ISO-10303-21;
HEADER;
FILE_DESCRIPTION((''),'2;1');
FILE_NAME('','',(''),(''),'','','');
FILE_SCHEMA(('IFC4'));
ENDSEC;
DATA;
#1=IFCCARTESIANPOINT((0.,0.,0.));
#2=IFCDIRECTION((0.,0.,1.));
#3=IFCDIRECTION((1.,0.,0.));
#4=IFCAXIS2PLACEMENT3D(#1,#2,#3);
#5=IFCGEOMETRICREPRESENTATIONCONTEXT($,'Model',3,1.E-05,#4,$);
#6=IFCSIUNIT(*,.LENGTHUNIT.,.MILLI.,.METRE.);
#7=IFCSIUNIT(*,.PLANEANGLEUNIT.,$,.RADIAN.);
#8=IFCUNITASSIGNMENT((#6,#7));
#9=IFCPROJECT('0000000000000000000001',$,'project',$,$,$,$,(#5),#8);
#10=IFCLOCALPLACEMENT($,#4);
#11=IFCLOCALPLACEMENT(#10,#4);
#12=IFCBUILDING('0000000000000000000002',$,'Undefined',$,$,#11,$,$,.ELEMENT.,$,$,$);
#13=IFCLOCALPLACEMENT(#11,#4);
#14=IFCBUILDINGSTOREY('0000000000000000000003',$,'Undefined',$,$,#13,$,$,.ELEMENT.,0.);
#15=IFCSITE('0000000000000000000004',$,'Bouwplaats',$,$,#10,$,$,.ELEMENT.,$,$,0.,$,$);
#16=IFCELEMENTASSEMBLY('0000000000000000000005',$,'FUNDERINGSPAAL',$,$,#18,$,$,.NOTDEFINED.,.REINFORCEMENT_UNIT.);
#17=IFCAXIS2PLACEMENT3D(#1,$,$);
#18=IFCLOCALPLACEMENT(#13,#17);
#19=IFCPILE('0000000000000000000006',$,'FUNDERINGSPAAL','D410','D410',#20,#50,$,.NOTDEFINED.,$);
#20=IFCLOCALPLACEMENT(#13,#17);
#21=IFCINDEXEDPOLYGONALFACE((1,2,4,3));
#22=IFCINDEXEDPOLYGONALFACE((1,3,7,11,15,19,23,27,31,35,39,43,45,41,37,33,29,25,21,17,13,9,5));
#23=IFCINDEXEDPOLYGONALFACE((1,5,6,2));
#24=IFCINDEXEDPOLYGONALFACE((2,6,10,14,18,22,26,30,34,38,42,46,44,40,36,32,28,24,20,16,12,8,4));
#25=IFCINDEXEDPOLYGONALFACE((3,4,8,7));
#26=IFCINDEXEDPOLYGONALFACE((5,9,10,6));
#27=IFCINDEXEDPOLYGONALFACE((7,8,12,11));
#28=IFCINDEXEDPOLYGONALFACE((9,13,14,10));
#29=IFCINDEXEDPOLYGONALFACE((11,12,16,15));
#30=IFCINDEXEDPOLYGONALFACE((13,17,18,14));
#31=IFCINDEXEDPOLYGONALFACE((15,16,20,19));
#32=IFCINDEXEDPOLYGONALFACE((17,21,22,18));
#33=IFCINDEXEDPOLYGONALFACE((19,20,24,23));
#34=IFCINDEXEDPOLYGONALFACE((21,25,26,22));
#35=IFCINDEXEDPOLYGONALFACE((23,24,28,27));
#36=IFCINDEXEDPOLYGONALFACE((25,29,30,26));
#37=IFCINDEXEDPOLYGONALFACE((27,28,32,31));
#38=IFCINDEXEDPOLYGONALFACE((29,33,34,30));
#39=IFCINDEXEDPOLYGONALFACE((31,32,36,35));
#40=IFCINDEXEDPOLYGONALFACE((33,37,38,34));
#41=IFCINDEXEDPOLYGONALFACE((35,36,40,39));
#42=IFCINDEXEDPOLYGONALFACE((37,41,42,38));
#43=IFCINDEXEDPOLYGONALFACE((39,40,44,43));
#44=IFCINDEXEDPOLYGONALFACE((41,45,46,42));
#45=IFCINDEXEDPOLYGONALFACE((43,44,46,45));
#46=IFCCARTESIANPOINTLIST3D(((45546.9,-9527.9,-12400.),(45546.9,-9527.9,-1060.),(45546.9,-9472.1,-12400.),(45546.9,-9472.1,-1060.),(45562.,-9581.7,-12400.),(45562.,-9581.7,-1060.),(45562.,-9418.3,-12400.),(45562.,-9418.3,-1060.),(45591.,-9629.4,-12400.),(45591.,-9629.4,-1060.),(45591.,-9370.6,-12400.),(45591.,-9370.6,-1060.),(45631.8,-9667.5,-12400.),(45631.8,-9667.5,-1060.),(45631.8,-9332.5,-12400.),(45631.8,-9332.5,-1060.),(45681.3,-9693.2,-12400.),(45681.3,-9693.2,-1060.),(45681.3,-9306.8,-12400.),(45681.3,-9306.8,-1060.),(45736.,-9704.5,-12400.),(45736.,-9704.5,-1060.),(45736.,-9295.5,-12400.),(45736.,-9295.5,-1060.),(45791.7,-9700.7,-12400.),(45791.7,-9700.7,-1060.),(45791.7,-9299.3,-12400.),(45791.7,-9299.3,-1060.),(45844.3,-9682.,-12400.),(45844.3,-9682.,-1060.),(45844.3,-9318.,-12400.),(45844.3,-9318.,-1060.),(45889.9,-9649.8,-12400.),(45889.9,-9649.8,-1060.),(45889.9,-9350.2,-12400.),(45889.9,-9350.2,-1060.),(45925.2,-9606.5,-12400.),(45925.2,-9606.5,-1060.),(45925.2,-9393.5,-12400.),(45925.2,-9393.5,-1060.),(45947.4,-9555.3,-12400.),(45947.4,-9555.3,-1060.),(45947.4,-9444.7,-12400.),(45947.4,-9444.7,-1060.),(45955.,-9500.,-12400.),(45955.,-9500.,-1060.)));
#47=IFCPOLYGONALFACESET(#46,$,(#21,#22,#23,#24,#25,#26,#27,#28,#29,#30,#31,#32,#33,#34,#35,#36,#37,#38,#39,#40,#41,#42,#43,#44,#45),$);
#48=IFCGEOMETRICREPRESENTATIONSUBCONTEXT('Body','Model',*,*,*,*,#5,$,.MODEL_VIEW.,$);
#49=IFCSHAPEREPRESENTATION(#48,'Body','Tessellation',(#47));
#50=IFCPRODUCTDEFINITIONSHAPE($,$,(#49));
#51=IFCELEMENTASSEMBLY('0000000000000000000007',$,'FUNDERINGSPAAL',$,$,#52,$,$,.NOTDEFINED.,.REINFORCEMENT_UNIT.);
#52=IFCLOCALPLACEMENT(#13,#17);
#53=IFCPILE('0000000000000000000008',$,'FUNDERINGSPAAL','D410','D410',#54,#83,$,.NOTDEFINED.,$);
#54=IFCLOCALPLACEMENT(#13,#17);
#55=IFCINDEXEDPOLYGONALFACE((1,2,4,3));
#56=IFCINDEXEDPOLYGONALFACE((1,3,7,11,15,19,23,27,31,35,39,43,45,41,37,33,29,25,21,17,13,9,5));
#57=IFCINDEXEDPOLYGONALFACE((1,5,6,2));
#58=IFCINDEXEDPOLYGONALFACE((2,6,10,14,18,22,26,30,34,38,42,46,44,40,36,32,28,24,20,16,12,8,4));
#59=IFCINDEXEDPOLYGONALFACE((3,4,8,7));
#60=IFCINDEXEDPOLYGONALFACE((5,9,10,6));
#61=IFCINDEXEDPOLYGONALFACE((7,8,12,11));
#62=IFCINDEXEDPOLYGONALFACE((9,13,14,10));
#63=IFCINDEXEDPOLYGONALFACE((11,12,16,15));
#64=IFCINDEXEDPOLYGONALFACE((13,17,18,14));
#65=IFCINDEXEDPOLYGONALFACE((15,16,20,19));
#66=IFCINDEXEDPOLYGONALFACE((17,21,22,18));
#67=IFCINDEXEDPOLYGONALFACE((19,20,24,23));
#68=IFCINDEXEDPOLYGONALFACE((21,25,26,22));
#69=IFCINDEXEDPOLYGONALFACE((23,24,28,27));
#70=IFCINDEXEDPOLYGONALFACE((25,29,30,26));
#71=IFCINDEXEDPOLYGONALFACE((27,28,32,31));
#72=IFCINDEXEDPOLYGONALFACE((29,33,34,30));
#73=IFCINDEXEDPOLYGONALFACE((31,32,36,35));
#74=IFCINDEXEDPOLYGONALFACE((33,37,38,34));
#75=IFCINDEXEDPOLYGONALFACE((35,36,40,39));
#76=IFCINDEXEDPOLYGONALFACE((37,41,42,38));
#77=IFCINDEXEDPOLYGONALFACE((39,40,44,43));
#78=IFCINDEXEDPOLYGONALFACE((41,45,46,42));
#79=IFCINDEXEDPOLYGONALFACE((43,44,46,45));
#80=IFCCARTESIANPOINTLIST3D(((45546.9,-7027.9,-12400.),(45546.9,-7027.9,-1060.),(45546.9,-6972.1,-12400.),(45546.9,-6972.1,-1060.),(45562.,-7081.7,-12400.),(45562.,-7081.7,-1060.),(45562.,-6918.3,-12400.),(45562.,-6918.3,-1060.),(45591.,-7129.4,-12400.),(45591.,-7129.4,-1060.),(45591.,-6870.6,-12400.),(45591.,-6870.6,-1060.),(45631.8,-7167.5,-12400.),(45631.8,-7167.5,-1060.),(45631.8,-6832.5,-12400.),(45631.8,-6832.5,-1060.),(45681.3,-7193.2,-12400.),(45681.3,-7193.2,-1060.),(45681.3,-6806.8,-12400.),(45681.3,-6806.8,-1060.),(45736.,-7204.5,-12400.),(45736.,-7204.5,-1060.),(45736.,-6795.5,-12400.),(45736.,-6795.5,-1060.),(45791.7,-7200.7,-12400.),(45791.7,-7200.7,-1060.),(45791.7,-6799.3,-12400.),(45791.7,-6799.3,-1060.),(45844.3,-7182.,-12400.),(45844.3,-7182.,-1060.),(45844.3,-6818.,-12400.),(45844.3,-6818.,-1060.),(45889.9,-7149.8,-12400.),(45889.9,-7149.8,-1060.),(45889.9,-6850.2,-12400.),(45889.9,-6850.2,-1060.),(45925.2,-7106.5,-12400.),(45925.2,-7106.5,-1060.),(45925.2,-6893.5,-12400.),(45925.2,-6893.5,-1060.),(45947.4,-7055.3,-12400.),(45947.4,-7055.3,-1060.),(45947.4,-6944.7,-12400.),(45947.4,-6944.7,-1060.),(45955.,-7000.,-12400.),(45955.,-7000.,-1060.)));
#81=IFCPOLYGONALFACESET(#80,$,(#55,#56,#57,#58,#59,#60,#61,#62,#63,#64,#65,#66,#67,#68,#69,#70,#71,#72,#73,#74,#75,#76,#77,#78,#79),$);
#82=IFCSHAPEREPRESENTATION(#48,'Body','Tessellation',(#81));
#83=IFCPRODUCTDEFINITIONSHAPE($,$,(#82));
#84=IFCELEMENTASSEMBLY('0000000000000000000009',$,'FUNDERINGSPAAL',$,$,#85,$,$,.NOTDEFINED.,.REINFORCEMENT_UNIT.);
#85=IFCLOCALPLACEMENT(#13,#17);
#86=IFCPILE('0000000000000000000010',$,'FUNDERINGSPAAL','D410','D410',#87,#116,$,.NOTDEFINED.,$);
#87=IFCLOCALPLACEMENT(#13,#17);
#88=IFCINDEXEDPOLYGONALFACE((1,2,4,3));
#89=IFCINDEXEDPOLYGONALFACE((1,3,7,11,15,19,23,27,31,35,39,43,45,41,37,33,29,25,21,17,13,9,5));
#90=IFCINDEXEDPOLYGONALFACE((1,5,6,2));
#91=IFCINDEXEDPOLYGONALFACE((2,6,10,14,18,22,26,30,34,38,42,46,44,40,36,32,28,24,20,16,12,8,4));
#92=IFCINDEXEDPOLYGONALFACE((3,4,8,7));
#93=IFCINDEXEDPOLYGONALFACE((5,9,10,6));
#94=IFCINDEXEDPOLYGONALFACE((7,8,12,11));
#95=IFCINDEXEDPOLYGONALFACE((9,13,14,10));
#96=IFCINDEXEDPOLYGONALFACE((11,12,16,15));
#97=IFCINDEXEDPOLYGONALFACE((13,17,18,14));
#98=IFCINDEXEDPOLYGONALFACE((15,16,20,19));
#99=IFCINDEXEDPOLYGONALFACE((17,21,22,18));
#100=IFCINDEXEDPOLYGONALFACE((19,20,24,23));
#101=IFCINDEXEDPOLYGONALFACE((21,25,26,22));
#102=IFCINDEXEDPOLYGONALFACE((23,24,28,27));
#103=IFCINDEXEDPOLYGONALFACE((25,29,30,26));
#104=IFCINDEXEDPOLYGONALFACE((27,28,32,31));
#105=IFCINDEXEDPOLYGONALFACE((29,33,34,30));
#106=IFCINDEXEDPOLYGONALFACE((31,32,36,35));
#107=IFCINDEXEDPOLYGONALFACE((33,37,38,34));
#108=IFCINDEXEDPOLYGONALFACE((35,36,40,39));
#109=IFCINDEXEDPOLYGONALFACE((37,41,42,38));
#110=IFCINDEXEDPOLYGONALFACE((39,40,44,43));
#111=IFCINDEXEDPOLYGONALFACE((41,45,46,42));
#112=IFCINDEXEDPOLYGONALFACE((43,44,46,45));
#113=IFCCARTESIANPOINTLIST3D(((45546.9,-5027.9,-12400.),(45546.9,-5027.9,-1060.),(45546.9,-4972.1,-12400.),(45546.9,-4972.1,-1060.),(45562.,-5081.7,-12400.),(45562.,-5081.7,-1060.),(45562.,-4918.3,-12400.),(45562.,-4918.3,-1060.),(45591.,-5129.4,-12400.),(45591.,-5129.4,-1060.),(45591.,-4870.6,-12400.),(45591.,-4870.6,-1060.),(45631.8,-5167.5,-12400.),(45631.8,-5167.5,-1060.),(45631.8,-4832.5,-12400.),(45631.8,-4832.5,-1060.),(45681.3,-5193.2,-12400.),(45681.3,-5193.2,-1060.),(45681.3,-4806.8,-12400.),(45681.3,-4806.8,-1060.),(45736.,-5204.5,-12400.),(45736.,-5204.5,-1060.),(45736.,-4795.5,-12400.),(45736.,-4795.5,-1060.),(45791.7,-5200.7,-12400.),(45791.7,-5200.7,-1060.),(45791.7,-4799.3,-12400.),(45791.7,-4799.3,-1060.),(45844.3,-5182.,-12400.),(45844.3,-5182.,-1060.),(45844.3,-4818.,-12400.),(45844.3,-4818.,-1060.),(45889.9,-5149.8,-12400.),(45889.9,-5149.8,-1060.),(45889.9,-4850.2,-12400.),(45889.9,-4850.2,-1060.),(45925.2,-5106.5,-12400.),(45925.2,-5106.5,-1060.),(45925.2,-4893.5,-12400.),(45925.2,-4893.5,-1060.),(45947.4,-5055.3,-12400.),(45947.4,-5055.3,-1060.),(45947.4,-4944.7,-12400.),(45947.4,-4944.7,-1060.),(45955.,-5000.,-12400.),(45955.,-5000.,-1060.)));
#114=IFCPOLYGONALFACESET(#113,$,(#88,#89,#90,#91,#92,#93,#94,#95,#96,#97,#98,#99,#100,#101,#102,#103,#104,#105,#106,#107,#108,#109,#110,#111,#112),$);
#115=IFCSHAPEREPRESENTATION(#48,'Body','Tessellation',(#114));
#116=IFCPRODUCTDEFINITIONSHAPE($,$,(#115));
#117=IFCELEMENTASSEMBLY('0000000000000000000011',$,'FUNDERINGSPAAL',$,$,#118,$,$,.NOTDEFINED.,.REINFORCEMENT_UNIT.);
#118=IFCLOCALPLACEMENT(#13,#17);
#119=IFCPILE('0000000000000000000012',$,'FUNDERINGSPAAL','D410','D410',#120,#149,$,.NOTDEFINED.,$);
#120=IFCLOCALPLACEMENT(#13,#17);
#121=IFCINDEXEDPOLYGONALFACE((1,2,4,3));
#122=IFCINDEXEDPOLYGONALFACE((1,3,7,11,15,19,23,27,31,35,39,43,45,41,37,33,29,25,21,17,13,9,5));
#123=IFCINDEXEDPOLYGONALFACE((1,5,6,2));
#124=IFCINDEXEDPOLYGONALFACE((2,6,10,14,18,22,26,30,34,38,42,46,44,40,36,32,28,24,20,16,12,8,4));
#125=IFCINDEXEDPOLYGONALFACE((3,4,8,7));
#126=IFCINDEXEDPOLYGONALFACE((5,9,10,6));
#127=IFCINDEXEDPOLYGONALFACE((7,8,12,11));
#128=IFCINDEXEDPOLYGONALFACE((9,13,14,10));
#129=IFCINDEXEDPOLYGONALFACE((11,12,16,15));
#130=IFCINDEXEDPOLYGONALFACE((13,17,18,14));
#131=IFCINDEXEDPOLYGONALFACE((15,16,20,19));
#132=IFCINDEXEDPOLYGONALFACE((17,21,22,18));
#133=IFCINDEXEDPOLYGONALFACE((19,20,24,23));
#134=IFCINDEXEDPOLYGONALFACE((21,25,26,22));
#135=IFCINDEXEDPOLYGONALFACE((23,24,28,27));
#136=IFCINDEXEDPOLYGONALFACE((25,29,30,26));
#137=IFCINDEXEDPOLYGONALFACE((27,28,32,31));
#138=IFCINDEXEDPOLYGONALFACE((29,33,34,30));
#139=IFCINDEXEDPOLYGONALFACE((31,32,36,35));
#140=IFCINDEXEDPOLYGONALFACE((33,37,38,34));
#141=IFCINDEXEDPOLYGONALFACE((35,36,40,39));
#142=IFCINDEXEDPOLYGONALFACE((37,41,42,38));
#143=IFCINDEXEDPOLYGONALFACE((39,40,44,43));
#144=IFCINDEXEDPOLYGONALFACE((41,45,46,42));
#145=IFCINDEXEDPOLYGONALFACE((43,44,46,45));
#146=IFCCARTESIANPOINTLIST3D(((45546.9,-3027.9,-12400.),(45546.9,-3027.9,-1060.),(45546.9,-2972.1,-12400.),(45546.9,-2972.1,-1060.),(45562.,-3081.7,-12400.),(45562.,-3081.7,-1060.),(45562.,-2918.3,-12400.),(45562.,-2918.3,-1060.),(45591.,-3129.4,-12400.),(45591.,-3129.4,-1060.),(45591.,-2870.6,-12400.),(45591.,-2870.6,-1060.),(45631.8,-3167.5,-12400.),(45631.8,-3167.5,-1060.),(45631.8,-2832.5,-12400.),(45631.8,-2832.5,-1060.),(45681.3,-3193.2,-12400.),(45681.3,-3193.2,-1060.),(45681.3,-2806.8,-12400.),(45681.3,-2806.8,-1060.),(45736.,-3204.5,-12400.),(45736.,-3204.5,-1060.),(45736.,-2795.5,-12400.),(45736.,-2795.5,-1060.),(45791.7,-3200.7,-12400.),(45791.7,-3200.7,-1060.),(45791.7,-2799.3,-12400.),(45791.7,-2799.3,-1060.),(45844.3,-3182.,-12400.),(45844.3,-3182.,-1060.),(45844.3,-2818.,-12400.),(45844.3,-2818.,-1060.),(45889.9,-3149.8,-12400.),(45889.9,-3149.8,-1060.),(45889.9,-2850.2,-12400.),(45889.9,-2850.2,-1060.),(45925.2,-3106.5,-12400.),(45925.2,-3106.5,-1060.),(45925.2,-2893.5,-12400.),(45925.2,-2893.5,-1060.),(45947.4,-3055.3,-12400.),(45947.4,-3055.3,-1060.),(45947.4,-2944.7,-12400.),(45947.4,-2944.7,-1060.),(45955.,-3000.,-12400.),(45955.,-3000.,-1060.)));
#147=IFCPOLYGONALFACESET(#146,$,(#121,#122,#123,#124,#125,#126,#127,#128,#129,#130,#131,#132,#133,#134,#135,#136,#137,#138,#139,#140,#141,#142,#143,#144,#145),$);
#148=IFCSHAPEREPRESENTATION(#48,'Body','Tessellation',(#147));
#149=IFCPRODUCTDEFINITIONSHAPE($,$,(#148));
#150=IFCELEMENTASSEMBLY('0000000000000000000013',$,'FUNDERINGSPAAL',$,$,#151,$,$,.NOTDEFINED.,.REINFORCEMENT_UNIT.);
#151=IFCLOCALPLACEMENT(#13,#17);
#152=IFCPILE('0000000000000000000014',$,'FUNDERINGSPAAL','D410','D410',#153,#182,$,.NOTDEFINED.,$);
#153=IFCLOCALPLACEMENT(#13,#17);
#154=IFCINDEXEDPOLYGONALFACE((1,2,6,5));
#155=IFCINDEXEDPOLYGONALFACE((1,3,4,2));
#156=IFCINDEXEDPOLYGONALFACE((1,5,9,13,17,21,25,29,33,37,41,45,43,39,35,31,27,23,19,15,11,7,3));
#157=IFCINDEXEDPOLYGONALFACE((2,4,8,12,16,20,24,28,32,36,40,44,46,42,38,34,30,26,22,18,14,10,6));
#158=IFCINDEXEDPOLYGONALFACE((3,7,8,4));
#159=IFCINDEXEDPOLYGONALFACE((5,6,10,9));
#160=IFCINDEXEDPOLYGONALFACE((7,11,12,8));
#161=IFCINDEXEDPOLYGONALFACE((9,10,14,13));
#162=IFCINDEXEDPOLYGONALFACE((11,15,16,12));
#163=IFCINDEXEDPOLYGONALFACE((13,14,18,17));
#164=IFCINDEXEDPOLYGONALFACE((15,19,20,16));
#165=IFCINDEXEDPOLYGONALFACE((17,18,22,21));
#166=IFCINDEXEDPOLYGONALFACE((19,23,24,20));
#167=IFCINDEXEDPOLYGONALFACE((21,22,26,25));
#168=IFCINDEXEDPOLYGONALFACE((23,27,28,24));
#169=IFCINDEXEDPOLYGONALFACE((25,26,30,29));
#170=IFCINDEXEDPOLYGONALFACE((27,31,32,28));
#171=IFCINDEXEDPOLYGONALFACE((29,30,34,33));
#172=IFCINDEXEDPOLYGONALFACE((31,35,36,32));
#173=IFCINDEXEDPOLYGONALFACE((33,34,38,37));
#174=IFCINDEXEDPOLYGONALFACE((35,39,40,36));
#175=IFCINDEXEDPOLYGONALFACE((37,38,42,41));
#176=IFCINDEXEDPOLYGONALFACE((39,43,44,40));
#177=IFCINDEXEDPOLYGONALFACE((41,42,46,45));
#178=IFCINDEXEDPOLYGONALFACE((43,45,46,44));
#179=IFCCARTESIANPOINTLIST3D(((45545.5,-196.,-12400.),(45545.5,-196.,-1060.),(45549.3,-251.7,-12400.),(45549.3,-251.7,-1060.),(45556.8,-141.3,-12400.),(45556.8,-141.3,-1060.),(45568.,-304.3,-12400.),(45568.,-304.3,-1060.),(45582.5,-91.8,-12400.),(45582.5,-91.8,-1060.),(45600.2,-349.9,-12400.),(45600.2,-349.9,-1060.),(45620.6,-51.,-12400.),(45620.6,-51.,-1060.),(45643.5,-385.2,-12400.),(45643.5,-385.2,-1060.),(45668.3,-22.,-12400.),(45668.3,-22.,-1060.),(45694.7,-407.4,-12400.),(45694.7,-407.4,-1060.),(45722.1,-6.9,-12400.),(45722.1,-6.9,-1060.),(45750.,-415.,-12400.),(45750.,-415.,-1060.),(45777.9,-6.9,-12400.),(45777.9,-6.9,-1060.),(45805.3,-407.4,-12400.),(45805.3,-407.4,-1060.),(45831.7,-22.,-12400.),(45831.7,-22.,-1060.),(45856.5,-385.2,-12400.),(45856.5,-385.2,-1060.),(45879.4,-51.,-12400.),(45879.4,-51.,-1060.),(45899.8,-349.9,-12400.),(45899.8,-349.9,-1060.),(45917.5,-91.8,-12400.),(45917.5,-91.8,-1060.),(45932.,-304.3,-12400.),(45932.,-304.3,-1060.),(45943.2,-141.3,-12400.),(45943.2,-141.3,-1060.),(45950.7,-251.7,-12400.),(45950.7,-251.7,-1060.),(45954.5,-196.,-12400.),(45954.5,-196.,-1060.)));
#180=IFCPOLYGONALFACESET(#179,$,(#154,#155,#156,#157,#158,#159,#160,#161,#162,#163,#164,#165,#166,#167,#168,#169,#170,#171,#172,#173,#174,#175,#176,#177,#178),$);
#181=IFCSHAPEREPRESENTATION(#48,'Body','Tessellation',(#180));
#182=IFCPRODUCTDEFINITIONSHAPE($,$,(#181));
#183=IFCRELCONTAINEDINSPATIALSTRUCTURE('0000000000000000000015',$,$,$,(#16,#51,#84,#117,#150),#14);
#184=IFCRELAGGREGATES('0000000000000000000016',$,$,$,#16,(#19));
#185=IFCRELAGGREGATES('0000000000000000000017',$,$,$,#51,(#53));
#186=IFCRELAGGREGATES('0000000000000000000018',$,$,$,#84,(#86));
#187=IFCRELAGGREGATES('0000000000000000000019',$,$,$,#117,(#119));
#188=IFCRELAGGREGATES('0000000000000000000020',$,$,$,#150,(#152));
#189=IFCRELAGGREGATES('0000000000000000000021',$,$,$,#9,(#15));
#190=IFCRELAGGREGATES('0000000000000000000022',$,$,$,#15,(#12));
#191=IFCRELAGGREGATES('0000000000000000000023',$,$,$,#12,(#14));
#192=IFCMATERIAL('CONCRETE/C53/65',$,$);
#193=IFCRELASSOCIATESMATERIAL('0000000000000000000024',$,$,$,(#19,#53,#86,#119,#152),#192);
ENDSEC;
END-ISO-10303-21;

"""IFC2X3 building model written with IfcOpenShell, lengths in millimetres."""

from ifc_helpers import new_model, si_unit, frame, origin_with_axes, origin_2d_with_axis, place, context, subcontext, project, spatial, circle, extrude, clip, halfspace, material, element, aggregate, save


model = new_model("IFC2X3")

# Units and contexts
model_context = context("Model", 3, precision=1e-05, world=origin_with_axes())
body_context = subcontext(model_context, "Body", "Model", "MODEL_VIEW")
ifc_project = project(units=[si_unit("LENGTHUNIT", "METRE", prefix="MILLI"), si_unit("PLANEANGLEUNIT", "RADIAN")], contexts=[model_context])

# Site, building, storey
site_placement = place(None, origin_with_axes())
site = spatial("IfcSite", under=ifc_project, at=site_placement, Name="Bouwplaats", CompositionType="ELEMENT", RefElevation=0.0)
building_placement = place(site_placement, origin_with_axes())
building = spatial("IfcBuilding", under=site, at=building_placement, Name="Undefined", CompositionType="ELEMENT")
storey_placement = place(building_placement, origin_with_axes())
storey = spatial("IfcBuildingStorey", under=building, at=storey_placement, Name="Undefined", CompositionType="ELEMENT", Elevation=0.0)

# Element assemblies, piles
ifc_material_1 = material(Name="CONCRETE/C53/65")
assembly_1_placement = place(storey_placement, origin_with_axes())
assembly_1 = element("IfcElementAssembly", 1, at=assembly_1_placement, inside=storey, Name="FUNDERINGSPAAL", AssemblyPlace="NOTDEFINED", PredefinedType="REINFORCEMENT_UNIT")
pile_1_placement = place(assembly_1_placement, frame((45750.0, -9500.0, -1060.0), z_axis=(0.0, 1.0, 0.0), x_axis=(0.0, 0.0, -1.0)))
pile_1 = element("IfcPile", 2, at=pile_1_placement, material=ifc_material_1, Name="FUNDERINGSPAAL", Description="D410", ObjectType="D410", PredefinedType="NOTDEFINED", context=body_context, shape_type="Clipping", body=[
    clip(extrude(circle(Radius=205.0, at=origin_2d_with_axis()), frame((11340.0, 0.0, 0.0), z_axis=(-1.0, 0.0, 0.0), x_axis=(0.0, -1.0, 0.0)), (0.0, 0.0, 1.0), 11340.0), halfspace(frame((0.0, 205.0, -205.0), z_axis=(-1.0, 0.0, 0.0), x_axis=(0.0, 0.0, 1.0)), False)),
])
aggregate(assembly_1, [pile_1])
assembly_2_placement = place(storey_placement, origin_with_axes())
assembly_2 = element("IfcElementAssembly", 3, at=assembly_2_placement, inside=storey, Name="FUNDERINGSPAAL", AssemblyPlace="NOTDEFINED", PredefinedType="REINFORCEMENT_UNIT")
pile_2_placement = place(assembly_2_placement, frame((45750.0, -7000.0, -1060.0), z_axis=(0.0, 1.0, 0.0), x_axis=(0.0, 0.0, -1.0)))
pile_2 = element("IfcPile", 4, at=pile_2_placement, material=ifc_material_1, Name="FUNDERINGSPAAL", Description="D410", ObjectType="D410", PredefinedType="NOTDEFINED", context=body_context, shape_type="Clipping", body=[
    clip(extrude(circle(Radius=205.0, at=origin_2d_with_axis()), frame((11340.0, 0.0, 0.0), z_axis=(-1.0, 0.0, 0.0), x_axis=(0.0, -1.0, 0.0)), (0.0, 0.0, 1.0), 11340.0), halfspace(frame((0.0, 205.0, -205.0), z_axis=(-1.0, 0.0, 0.0), x_axis=(0.0, 0.0, 1.0)), False)),
])
aggregate(assembly_2, [pile_2])
assembly_3_placement = place(storey_placement, origin_with_axes())
assembly_3 = element("IfcElementAssembly", 5, at=assembly_3_placement, inside=storey, Name="FUNDERINGSPAAL", AssemblyPlace="NOTDEFINED", PredefinedType="REINFORCEMENT_UNIT")
pile_3_placement = place(assembly_3_placement, frame((45750.0, -5000.0, -1060.0), z_axis=(0.0, 1.0, 0.0), x_axis=(0.0, 0.0, -1.0)))
pile_3 = element("IfcPile", 6, at=pile_3_placement, material=ifc_material_1, Name="FUNDERINGSPAAL", Description="D410", ObjectType="D410", PredefinedType="NOTDEFINED", context=body_context, shape_type="Clipping", body=[
    clip(extrude(circle(Radius=205.0, at=origin_2d_with_axis()), frame((11340.0, 0.0, 0.0), z_axis=(-1.0, 0.0, 0.0), x_axis=(0.0, -1.0, 0.0)), (0.0, 0.0, 1.0), 11340.0), halfspace(frame((0.0, 205.0, -205.0), z_axis=(-1.0, 0.0, 0.0), x_axis=(0.0, 0.0, 1.0)), False)),
])
aggregate(assembly_3, [pile_3])
assembly_4_placement = place(storey_placement, origin_with_axes())
assembly_4 = element("IfcElementAssembly", 7, at=assembly_4_placement, inside=storey, Name="FUNDERINGSPAAL", AssemblyPlace="NOTDEFINED", PredefinedType="REINFORCEMENT_UNIT")
pile_4_placement = place(assembly_4_placement, frame((45750.0, -3000.0, -1060.0), z_axis=(0.0, 1.0, 0.0), x_axis=(0.0, 0.0, -1.0)))
pile_4 = element("IfcPile", 8, at=pile_4_placement, material=ifc_material_1, Name="FUNDERINGSPAAL", Description="D410", ObjectType="D410", PredefinedType="NOTDEFINED", context=body_context, shape_type="Clipping", body=[
    clip(extrude(circle(Radius=205.0, at=origin_2d_with_axis()), frame((11340.0, 0.0, 0.0), z_axis=(-1.0, 0.0, 0.0), x_axis=(0.0, -1.0, 0.0)), (0.0, 0.0, 1.0), 11340.0), halfspace(frame((0.0, 205.0, -205.0), z_axis=(-1.0, 0.0, 0.0), x_axis=(0.0, 0.0, 1.0)), False)),
])
aggregate(assembly_4, [pile_4])
assembly_5_placement = place(storey_placement, origin_with_axes())
assembly_5 = element("IfcElementAssembly", 9, at=assembly_5_placement, inside=storey, Name="FUNDERINGSPAAL", AssemblyPlace="NOTDEFINED", PredefinedType="REINFORCEMENT_UNIT")
pile_5_placement = place(assembly_5_placement, frame((45750.0, -210.0, -1060.0), z_axis=(1.0, 0.0, 0.0), x_axis=(0.0, 0.0, -1.0)))
pile_5 = element("IfcPile", 10, at=pile_5_placement, material=ifc_material_1, Name="FUNDERINGSPAAL", Description="D410", ObjectType="D410", PredefinedType="NOTDEFINED", context=body_context, shape_type="Clipping", body=[
    clip(extrude(circle(Radius=205.0, at=origin_2d_with_axis()), frame((11340.0, 0.0, 0.0), z_axis=(-1.0, 0.0, 0.0), x_axis=(0.0, -1.0, 0.0)), (0.0, 0.0, 1.0), 11340.0), halfspace(frame((0.0, 205.0, -205.0), z_axis=(-1.0, 0.0, 0.0), x_axis=(0.0, 0.0, 1.0)), False)),
])
aggregate(assembly_5, [pile_5])

save(model, "model.ifc")
